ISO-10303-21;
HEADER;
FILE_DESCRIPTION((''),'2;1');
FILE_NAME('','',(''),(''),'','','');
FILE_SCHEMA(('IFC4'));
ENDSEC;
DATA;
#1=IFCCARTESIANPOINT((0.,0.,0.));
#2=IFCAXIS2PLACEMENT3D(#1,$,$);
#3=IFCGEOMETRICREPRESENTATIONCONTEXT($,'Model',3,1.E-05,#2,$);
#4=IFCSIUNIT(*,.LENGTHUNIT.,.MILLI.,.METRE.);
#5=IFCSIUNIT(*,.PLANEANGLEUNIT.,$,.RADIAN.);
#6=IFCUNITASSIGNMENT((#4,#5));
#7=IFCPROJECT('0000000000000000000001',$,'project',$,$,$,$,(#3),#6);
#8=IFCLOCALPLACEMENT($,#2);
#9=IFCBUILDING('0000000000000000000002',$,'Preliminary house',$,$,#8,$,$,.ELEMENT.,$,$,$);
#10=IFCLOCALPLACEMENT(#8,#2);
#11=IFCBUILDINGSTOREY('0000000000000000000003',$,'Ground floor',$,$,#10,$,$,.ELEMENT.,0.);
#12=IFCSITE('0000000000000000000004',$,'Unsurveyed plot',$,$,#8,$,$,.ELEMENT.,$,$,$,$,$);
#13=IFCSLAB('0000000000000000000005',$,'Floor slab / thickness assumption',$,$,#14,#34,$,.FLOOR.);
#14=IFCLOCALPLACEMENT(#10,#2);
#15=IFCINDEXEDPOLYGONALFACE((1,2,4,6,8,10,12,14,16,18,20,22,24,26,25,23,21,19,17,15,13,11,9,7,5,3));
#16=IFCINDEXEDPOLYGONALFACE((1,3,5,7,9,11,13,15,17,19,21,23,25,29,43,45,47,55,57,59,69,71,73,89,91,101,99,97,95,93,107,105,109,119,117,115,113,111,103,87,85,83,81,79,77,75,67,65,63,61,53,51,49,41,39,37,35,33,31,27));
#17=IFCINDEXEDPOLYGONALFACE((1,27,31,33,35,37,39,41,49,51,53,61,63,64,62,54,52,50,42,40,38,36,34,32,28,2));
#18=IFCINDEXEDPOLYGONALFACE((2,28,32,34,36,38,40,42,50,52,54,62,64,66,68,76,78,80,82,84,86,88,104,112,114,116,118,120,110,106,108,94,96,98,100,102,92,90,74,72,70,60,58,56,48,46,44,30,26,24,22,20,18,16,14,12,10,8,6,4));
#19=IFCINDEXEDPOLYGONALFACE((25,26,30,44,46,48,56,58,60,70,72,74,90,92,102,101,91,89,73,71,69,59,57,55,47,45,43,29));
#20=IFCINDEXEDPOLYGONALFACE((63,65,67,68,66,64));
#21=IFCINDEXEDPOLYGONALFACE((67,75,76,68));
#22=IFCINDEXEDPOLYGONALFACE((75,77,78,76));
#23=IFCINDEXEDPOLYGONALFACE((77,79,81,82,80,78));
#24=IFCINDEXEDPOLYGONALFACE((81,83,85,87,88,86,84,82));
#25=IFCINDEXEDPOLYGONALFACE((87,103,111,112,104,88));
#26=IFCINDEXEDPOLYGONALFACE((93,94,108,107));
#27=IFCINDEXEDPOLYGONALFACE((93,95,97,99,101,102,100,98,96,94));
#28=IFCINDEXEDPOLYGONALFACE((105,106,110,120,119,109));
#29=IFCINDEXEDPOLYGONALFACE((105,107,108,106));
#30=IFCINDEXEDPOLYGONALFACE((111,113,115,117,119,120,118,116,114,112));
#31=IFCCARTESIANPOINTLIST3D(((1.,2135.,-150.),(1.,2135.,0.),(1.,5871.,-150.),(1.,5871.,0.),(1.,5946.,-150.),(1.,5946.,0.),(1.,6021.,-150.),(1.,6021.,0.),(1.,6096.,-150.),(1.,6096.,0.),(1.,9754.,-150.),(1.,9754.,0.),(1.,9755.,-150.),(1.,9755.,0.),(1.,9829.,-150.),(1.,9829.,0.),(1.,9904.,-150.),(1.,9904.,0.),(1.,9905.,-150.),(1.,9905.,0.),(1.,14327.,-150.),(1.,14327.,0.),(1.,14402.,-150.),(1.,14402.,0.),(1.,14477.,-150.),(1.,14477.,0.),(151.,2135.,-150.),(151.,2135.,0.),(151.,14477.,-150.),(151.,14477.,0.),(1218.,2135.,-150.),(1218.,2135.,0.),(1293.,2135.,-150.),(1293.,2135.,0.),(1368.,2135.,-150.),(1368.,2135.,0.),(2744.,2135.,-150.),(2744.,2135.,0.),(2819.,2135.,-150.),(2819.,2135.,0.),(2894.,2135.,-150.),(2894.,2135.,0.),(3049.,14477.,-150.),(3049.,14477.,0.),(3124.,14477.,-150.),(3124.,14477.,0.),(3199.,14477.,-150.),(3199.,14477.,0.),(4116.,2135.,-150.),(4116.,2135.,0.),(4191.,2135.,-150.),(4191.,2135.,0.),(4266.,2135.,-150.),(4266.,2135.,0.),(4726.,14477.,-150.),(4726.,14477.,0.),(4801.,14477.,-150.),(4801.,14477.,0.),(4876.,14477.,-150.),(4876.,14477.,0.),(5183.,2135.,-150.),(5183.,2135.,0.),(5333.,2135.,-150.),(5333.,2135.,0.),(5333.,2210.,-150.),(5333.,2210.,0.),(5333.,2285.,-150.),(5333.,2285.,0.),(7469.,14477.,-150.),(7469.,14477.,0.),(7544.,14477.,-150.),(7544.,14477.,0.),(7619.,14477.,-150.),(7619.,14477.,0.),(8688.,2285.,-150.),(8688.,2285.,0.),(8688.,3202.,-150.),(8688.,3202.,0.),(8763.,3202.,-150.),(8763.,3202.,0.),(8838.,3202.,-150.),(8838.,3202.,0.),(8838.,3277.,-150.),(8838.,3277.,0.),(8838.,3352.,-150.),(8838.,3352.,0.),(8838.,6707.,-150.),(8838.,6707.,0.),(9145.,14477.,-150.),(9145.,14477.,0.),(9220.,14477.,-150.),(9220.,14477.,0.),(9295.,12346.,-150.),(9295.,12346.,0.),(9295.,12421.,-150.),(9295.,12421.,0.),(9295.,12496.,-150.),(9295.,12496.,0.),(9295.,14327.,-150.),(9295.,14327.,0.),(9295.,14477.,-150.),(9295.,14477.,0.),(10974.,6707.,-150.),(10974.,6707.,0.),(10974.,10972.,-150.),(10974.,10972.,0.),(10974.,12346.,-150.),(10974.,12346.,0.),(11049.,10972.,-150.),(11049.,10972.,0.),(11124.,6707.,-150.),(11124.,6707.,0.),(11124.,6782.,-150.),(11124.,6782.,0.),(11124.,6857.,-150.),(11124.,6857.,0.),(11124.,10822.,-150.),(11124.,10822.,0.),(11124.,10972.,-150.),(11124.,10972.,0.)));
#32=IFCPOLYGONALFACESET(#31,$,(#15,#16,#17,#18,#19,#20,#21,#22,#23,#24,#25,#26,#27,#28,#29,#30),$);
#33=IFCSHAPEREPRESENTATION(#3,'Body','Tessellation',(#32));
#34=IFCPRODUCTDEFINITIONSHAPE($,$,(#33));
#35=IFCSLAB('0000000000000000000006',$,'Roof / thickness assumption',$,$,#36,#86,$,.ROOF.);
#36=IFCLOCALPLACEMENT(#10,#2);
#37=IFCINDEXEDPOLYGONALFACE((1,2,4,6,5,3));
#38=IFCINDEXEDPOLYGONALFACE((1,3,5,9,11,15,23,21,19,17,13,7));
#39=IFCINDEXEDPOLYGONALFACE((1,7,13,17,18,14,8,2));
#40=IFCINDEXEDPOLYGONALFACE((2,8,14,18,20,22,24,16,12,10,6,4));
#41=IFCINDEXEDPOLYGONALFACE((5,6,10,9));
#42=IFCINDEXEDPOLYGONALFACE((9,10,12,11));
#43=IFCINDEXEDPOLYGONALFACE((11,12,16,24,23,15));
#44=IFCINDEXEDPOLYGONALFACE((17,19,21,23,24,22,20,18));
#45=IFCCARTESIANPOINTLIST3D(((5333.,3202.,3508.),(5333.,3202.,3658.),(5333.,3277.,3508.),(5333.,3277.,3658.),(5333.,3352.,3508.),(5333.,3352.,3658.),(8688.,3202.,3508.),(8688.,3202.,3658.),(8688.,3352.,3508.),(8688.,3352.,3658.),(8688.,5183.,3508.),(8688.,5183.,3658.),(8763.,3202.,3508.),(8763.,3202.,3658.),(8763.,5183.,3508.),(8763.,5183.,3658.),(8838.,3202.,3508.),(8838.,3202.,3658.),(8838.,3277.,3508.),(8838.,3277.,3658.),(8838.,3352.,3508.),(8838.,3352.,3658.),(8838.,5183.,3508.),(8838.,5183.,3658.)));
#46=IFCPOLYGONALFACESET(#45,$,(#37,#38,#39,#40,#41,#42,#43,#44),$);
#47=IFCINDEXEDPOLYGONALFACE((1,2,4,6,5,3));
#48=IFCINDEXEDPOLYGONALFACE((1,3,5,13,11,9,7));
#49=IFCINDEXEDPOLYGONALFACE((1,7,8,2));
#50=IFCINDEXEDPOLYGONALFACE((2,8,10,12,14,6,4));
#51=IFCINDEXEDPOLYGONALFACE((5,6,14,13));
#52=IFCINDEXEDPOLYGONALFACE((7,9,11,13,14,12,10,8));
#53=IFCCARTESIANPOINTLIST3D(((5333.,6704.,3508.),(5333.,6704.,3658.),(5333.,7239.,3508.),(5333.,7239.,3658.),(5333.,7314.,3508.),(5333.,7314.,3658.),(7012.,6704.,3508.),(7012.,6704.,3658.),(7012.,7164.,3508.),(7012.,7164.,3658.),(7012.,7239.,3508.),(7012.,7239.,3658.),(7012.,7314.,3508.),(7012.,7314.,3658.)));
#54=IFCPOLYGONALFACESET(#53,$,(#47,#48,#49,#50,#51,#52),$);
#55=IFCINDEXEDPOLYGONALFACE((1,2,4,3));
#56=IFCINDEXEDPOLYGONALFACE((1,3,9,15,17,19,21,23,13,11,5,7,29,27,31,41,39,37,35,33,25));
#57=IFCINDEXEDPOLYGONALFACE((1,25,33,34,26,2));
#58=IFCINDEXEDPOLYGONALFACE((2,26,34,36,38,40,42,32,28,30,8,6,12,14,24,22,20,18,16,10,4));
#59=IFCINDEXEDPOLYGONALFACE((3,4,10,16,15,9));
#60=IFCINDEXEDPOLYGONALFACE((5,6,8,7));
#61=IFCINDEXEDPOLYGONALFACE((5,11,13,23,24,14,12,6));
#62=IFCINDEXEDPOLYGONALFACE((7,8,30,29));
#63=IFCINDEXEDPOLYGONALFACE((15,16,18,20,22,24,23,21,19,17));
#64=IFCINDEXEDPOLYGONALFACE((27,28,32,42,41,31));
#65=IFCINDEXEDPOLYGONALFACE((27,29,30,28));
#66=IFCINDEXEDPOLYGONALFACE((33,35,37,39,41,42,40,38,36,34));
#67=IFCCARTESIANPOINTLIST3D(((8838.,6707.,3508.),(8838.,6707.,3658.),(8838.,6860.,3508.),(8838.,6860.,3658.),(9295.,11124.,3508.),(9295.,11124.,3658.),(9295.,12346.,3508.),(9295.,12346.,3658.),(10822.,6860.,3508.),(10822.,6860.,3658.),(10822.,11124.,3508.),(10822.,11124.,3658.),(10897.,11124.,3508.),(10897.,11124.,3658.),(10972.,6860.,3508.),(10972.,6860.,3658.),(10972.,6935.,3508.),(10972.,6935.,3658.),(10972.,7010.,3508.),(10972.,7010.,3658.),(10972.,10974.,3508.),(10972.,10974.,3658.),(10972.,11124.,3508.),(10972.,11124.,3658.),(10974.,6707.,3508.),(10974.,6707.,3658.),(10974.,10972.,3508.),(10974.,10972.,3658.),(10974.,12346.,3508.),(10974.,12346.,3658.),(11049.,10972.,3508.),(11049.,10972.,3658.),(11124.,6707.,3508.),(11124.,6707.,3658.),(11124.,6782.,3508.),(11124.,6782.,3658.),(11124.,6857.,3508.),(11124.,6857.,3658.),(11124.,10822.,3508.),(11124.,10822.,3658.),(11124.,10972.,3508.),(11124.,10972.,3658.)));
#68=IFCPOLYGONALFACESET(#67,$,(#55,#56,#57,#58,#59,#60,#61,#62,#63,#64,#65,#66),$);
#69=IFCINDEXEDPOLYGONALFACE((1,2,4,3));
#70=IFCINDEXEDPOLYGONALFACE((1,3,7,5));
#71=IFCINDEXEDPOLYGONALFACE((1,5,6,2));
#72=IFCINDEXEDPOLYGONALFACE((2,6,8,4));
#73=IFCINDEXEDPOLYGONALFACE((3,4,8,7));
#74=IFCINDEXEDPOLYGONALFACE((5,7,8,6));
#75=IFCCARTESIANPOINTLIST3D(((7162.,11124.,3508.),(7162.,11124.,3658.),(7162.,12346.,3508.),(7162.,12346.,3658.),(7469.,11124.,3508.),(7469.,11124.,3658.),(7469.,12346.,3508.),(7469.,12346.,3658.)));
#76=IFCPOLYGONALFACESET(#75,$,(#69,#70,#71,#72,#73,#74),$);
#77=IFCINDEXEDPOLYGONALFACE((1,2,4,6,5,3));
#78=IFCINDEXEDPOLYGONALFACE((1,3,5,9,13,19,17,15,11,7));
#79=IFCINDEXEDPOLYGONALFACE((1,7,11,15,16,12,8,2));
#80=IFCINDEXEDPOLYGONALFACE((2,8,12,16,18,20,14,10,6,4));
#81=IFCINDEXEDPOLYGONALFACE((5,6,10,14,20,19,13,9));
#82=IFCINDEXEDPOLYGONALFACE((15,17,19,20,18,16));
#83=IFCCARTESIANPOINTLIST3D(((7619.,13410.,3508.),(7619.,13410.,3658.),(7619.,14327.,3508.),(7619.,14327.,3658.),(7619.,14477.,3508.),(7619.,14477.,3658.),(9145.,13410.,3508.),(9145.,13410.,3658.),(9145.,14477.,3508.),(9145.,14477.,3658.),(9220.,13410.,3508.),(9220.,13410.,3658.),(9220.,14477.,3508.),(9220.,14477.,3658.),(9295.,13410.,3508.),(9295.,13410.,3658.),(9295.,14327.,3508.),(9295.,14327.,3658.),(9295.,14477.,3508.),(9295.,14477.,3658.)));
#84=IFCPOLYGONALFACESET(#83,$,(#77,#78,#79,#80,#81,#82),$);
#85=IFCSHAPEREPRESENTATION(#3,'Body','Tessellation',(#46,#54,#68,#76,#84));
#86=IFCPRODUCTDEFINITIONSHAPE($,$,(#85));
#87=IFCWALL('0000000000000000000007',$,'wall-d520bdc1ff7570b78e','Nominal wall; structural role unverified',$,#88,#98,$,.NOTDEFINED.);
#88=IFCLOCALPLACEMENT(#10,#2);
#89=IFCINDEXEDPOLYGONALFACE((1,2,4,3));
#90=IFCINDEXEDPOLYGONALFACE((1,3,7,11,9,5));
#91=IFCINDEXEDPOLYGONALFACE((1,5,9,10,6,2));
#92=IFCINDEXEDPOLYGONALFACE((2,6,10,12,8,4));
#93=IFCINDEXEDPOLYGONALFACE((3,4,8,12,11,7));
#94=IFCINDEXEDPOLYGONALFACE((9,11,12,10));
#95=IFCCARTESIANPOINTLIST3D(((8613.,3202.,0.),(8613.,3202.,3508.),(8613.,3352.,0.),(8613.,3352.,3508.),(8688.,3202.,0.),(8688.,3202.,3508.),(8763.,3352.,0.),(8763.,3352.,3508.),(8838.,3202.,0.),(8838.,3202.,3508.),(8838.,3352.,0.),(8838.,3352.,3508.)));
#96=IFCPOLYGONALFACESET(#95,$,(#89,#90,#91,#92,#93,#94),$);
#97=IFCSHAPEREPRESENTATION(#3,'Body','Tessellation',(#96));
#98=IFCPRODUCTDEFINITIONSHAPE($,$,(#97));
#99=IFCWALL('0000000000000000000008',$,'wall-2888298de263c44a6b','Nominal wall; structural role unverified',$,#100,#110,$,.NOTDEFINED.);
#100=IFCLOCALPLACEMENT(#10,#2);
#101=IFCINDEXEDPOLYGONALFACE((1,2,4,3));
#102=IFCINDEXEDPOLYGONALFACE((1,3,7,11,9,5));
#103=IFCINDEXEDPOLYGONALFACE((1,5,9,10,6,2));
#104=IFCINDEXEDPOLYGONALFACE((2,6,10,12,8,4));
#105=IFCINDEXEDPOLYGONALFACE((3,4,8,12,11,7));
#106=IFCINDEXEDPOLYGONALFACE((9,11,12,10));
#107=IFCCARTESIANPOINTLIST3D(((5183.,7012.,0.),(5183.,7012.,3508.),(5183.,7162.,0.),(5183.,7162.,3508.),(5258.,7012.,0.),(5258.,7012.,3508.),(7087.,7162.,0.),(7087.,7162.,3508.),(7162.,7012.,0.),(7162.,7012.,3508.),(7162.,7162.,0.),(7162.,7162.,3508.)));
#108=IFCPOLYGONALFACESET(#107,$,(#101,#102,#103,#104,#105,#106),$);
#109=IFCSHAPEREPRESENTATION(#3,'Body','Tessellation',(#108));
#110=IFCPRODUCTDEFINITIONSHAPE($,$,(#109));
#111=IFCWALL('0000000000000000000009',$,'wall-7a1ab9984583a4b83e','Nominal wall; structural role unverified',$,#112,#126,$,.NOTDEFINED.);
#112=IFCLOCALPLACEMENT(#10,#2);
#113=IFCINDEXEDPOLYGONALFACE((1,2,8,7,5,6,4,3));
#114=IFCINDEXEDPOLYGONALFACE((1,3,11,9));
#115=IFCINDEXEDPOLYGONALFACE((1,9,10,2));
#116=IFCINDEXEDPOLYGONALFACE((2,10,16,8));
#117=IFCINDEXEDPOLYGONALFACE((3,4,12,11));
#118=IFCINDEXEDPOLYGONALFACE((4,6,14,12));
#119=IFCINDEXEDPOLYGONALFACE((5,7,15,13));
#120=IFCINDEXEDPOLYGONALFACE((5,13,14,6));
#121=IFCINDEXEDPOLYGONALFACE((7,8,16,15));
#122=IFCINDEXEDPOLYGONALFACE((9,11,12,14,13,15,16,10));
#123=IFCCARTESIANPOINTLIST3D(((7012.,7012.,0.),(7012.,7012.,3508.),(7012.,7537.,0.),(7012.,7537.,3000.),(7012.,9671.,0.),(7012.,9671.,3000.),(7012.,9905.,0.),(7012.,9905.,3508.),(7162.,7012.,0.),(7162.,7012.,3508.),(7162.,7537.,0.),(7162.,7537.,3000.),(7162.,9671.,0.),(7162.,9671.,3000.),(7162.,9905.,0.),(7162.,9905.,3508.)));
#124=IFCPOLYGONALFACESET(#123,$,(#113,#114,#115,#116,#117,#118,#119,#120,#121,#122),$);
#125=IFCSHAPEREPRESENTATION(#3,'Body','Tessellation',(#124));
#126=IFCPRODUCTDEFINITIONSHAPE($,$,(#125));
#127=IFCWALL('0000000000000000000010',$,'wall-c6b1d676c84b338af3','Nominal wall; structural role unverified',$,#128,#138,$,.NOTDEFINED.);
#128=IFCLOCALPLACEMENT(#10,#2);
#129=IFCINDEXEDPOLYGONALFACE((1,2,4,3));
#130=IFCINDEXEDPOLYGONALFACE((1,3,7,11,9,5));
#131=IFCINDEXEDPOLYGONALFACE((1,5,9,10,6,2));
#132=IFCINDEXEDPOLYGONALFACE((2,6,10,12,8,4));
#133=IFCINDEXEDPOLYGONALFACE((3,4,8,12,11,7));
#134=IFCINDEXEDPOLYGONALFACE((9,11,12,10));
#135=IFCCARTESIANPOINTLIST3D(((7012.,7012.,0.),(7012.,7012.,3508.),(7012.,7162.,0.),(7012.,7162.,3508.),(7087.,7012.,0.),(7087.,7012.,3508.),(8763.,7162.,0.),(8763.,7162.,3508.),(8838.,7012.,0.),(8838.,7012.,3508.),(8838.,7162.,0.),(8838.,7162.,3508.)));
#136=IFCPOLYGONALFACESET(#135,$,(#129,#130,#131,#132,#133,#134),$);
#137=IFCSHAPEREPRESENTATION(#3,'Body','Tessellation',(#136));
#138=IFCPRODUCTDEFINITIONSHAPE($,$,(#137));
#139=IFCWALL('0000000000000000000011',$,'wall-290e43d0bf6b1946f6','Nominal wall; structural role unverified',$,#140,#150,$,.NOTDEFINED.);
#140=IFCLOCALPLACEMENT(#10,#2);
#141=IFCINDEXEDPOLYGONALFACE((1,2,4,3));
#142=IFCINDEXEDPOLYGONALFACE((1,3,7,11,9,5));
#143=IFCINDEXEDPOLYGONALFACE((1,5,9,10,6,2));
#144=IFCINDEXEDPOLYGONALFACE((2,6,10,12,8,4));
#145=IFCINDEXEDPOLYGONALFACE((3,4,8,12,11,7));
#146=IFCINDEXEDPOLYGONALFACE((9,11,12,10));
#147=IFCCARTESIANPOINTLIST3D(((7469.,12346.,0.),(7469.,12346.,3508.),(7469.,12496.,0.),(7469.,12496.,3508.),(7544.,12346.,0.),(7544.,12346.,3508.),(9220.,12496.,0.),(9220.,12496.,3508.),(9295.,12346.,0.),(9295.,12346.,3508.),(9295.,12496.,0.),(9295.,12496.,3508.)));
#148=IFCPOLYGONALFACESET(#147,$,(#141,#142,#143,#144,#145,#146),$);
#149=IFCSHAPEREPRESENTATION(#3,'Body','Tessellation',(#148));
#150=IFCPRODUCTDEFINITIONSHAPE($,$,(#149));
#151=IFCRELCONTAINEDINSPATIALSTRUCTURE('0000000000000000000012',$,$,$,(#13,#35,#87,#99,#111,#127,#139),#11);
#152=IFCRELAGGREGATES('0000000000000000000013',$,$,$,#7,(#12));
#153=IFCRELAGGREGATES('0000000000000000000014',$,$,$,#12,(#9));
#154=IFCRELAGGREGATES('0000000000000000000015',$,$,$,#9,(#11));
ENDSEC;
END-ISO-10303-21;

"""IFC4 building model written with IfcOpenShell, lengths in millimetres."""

from ifc_helpers import new_model, si_unit, frame, origin, place, context, project, spatial, polyline, outline, extrude, element, save


model = new_model("IFC4")

# Units and contexts
model_context = context("Model", 3, precision=1e-05, world=origin())
ifc_project = project(units=[si_unit("LENGTHUNIT", "METRE", prefix="MILLI"), si_unit("PLANEANGLEUNIT", "RADIAN")], contexts=[model_context])

# Site, building, storey
placement_1 = place(None, origin())
site = spatial("IfcSite", under=ifc_project, at=placement_1, Name="Unsurveyed plot", CompositionType="ELEMENT")
building = spatial("IfcBuilding", under=site, at=placement_1, Name="Preliminary house", CompositionType="ELEMENT")
placement_2 = place(placement_1, origin())
storey = spatial("IfcBuildingStorey", under=building, at=placement_2, Name="Ground floor", CompositionType="ELEMENT", Elevation=0.0)

# Slabs
element("IfcSlab", 1, at=placement_2, inside=storey, Name="Floor slab / thickness assumption", PredefinedType="FLOOR", context=model_context, shape_type="SweptSolid", body=[
    extrude(outline(polyline([(1368.0, 2135.0), (1293.0, 2135.0), (1218.0, 2135.0), (151.0, 2135.0), (1.0, 2135.0), (1.0, 5871.0), (1.0, 5946.0), (1.0, 6021.0), (1.0, 6096.0), (1.0, 9754.0), (1.0, 9755.0), (1.0, 9829.0), (1.0, 9904.0), (1.0, 9905.0), (1.0, 14327.0), (1.0, 14402.0), (1.0, 14477.0), (151.0, 14477.0), (3049.0, 14477.0), (3124.0, 14477.0), (3199.0, 14477.0), (4726.0, 14477.0), (4801.0, 14477.0), (4876.0, 14477.0), (7469.0, 14477.0), (7544.0, 14477.0), (7619.0, 14477.0), (9145.0, 14477.0), (9220.0, 14477.0), (9295.0, 14477.0), (9295.0, 14327.0), (9295.0, 12496.0), (9295.0, 12421.0), (9295.0, 12346.0), (10974.0, 12346.0), (10974.0, 10972.0), (11049.0, 10972.0), (11124.0, 10972.0), (11124.0, 10822.0), (11124.0, 6857.0), (11124.0, 6782.0), (11124.0, 6707.0), (10974.0, 6707.0), (8838.0, 6707.0), (8838.0, 3352.0), (8838.0, 3277.0), (8838.0, 3202.0), (8763.0, 3202.0), (8688.0, 3202.0), (8688.0, 2285.0), (5333.0, 2285.0), (5333.0, 2210.0), (5333.0, 2135.0), (5183.0, 2135.0), (4266.0, 2135.0), (4191.0, 2135.0), (4116.0, 2135.0), (2894.0, 2135.0), (2819.0, 2135.0), (2744.0, 2135.0), (1368.0, 2135.0)])), frame((0.0, 0.0, -150.0)), (0.0, 0.0, 1.0), 150.0),
])
element("IfcSlab", 2, at=placement_2, inside=storey, Name="Roof / thickness assumption", PredefinedType="ROOF", context=model_context, shape_type="SweptSolid", body=[
    extrude(outline(polyline([(8838.0, 3202.0), (8763.0, 3202.0), (8688.0, 3202.0), (5333.0, 3202.0), (5333.0, 3277.0), (5333.0, 3352.0), (8688.0, 3352.0), (8688.0, 5183.0), (8763.0, 5183.0), (8838.0, 5183.0), (8838.0, 3352.0), (8838.0, 3277.0), (8838.0, 3202.0)])), frame((0.0, 0.0, 3508.0)), (0.0, 0.0, 1.0), 150.0),
    extrude(outline(polyline([(7012.0, 7164.0), (7012.0, 6704.0), (5333.0, 6704.0), (5333.0, 7239.0), (5333.0, 7314.0), (7012.0, 7314.0), (7012.0, 7239.0), (7012.0, 7164.0)])), frame((0.0, 0.0, 3508.0)), (0.0, 0.0, 1.0), 150.0),
    extrude(outline(polyline([(11049.0, 10972.0), (11124.0, 10972.0), (11124.0, 10822.0), (11124.0, 6857.0), (11124.0, 6782.0), (11124.0, 6707.0), (10974.0, 6707.0), (8838.0, 6707.0), (8838.0, 6860.0), (10822.0, 6860.0), (10972.0, 6860.0), (10972.0, 6935.0), (10972.0, 7010.0), (10972.0, 10974.0), (10972.0, 11124.0), (10897.0, 11124.0), (10822.0, 11124.0), (9295.0, 11124.0), (9295.0, 12346.0), (10974.0, 12346.0), (10974.0, 10972.0), (11049.0, 10972.0)])), frame((0.0, 0.0, 3508.0)), (0.0, 0.0, 1.0), 150.0),
    extrude(outline(polyline([(7162.0, 12346.0), (7469.0, 12346.0), (7469.0, 11124.0), (7162.0, 11124.0), (7162.0, 12346.0)])), frame((0.0, 0.0, 3508.0)), (0.0, 0.0, 1.0), 150.0),
    extrude(outline(polyline([(9295.0, 14327.0), (9295.0, 13410.0), (9220.0, 13410.0), (9145.0, 13410.0), (7619.0, 13410.0), (7619.0, 14327.0), (7619.0, 14477.0), (9145.0, 14477.0), (9220.0, 14477.0), (9295.0, 14477.0), (9295.0, 14327.0)])), frame((0.0, 0.0, 3508.0)), (0.0, 0.0, 1.0), 150.0),
])

# Walls
element("IfcWall", 3, at=placement_2, inside=storey, Name="wall-d520bdc1ff7570b78e", Description="Nominal wall; structural role unverified", PredefinedType="NOTDEFINED", context=model_context, shape_type="SweptSolid", body=[
    extrude(outline(polyline([(8763.0, 3352.0), (8838.0, 3352.0), (8838.0, 3202.0), (8688.0, 3202.0), (8613.0, 3202.0), (8613.0, 3352.0), (8763.0, 3352.0)])), origin(), (0.0, 0.0, 1.0), 3508.0),
])
element("IfcWall", 4, at=placement_2, inside=storey, Name="wall-2888298de263c44a6b", Description="Nominal wall; structural role unverified", PredefinedType="NOTDEFINED", context=model_context, shape_type="SweptSolid", body=[
    extrude(outline(polyline([(7087.0, 7162.0), (7162.0, 7162.0), (7162.0, 7012.0), (5258.0, 7012.0), (5183.0, 7012.0), (5183.0, 7162.0), (7087.0, 7162.0)])), origin(), (0.0, 0.0, 1.0), 3508.0),
])

# Wall, opening
wall_1 = element("IfcWall", 5, at=placement_2, inside=storey, Name="wall-7a1ab9984583a4b83e", Description="Nominal wall; structural role unverified", PredefinedType="NOTDEFINED", context=model_context, shape_type="SweptSolid", body=[
    extrude(outline(polyline([(7012.0, 9830.0), (7012.0, 9905.0), (7162.0, 9905.0), (7162.0, 7087.0), (7162.0, 7012.0), (7012.0, 7012.0), (7012.0, 9830.0)])), origin(), (0.0, 0.0, 1.0), 3508.0),
])
element("IfcOpeningElement", 6, at=placement_2, cuts=wall_1, PredefinedType="OPENING", context=model_context, shape_type="SweptSolid", body=[
    extrude(outline(polyline([(7537.0, 7537.0), (7537.0, 9671.0), (6637.0, 9671.0), (6637.0, 7537.0), (7537.0, 7537.0)])), origin(), (0.0, 0.0, 1.0), 3000.0),
])

# Wall
element("IfcWall", 7, at=placement_2, inside=storey, Name="wall-c6b1d676c84b338af3", Description="Nominal wall; structural role unverified", PredefinedType="NOTDEFINED", context=model_context, shape_type="SweptSolid", body=[
    extrude(outline(polyline([(8763.0, 7162.0), (8838.0, 7162.0), (8838.0, 7012.0), (7087.0, 7012.0), (7012.0, 7012.0), (7012.0, 7162.0), (8763.0, 7162.0)])), origin(), (0.0, 0.0, 1.0), 3508.0),
])

# Wall
element("IfcWall", 8, at=placement_2, inside=storey, Name="wall-290e43d0bf6b1946f6", Description="Nominal wall; structural role unverified", PredefinedType="NOTDEFINED", context=model_context, shape_type="SweptSolid", body=[
    extrude(outline(polyline([(9220.0, 12496.0), (9295.0, 12496.0), (9295.0, 12346.0), (7544.0, 12346.0), (7469.0, 12346.0), (7469.0, 12496.0), (9220.0, 12496.0)])), origin(), (0.0, 0.0, 1.0), 3508.0),
])

save(model, "model.ifc")
